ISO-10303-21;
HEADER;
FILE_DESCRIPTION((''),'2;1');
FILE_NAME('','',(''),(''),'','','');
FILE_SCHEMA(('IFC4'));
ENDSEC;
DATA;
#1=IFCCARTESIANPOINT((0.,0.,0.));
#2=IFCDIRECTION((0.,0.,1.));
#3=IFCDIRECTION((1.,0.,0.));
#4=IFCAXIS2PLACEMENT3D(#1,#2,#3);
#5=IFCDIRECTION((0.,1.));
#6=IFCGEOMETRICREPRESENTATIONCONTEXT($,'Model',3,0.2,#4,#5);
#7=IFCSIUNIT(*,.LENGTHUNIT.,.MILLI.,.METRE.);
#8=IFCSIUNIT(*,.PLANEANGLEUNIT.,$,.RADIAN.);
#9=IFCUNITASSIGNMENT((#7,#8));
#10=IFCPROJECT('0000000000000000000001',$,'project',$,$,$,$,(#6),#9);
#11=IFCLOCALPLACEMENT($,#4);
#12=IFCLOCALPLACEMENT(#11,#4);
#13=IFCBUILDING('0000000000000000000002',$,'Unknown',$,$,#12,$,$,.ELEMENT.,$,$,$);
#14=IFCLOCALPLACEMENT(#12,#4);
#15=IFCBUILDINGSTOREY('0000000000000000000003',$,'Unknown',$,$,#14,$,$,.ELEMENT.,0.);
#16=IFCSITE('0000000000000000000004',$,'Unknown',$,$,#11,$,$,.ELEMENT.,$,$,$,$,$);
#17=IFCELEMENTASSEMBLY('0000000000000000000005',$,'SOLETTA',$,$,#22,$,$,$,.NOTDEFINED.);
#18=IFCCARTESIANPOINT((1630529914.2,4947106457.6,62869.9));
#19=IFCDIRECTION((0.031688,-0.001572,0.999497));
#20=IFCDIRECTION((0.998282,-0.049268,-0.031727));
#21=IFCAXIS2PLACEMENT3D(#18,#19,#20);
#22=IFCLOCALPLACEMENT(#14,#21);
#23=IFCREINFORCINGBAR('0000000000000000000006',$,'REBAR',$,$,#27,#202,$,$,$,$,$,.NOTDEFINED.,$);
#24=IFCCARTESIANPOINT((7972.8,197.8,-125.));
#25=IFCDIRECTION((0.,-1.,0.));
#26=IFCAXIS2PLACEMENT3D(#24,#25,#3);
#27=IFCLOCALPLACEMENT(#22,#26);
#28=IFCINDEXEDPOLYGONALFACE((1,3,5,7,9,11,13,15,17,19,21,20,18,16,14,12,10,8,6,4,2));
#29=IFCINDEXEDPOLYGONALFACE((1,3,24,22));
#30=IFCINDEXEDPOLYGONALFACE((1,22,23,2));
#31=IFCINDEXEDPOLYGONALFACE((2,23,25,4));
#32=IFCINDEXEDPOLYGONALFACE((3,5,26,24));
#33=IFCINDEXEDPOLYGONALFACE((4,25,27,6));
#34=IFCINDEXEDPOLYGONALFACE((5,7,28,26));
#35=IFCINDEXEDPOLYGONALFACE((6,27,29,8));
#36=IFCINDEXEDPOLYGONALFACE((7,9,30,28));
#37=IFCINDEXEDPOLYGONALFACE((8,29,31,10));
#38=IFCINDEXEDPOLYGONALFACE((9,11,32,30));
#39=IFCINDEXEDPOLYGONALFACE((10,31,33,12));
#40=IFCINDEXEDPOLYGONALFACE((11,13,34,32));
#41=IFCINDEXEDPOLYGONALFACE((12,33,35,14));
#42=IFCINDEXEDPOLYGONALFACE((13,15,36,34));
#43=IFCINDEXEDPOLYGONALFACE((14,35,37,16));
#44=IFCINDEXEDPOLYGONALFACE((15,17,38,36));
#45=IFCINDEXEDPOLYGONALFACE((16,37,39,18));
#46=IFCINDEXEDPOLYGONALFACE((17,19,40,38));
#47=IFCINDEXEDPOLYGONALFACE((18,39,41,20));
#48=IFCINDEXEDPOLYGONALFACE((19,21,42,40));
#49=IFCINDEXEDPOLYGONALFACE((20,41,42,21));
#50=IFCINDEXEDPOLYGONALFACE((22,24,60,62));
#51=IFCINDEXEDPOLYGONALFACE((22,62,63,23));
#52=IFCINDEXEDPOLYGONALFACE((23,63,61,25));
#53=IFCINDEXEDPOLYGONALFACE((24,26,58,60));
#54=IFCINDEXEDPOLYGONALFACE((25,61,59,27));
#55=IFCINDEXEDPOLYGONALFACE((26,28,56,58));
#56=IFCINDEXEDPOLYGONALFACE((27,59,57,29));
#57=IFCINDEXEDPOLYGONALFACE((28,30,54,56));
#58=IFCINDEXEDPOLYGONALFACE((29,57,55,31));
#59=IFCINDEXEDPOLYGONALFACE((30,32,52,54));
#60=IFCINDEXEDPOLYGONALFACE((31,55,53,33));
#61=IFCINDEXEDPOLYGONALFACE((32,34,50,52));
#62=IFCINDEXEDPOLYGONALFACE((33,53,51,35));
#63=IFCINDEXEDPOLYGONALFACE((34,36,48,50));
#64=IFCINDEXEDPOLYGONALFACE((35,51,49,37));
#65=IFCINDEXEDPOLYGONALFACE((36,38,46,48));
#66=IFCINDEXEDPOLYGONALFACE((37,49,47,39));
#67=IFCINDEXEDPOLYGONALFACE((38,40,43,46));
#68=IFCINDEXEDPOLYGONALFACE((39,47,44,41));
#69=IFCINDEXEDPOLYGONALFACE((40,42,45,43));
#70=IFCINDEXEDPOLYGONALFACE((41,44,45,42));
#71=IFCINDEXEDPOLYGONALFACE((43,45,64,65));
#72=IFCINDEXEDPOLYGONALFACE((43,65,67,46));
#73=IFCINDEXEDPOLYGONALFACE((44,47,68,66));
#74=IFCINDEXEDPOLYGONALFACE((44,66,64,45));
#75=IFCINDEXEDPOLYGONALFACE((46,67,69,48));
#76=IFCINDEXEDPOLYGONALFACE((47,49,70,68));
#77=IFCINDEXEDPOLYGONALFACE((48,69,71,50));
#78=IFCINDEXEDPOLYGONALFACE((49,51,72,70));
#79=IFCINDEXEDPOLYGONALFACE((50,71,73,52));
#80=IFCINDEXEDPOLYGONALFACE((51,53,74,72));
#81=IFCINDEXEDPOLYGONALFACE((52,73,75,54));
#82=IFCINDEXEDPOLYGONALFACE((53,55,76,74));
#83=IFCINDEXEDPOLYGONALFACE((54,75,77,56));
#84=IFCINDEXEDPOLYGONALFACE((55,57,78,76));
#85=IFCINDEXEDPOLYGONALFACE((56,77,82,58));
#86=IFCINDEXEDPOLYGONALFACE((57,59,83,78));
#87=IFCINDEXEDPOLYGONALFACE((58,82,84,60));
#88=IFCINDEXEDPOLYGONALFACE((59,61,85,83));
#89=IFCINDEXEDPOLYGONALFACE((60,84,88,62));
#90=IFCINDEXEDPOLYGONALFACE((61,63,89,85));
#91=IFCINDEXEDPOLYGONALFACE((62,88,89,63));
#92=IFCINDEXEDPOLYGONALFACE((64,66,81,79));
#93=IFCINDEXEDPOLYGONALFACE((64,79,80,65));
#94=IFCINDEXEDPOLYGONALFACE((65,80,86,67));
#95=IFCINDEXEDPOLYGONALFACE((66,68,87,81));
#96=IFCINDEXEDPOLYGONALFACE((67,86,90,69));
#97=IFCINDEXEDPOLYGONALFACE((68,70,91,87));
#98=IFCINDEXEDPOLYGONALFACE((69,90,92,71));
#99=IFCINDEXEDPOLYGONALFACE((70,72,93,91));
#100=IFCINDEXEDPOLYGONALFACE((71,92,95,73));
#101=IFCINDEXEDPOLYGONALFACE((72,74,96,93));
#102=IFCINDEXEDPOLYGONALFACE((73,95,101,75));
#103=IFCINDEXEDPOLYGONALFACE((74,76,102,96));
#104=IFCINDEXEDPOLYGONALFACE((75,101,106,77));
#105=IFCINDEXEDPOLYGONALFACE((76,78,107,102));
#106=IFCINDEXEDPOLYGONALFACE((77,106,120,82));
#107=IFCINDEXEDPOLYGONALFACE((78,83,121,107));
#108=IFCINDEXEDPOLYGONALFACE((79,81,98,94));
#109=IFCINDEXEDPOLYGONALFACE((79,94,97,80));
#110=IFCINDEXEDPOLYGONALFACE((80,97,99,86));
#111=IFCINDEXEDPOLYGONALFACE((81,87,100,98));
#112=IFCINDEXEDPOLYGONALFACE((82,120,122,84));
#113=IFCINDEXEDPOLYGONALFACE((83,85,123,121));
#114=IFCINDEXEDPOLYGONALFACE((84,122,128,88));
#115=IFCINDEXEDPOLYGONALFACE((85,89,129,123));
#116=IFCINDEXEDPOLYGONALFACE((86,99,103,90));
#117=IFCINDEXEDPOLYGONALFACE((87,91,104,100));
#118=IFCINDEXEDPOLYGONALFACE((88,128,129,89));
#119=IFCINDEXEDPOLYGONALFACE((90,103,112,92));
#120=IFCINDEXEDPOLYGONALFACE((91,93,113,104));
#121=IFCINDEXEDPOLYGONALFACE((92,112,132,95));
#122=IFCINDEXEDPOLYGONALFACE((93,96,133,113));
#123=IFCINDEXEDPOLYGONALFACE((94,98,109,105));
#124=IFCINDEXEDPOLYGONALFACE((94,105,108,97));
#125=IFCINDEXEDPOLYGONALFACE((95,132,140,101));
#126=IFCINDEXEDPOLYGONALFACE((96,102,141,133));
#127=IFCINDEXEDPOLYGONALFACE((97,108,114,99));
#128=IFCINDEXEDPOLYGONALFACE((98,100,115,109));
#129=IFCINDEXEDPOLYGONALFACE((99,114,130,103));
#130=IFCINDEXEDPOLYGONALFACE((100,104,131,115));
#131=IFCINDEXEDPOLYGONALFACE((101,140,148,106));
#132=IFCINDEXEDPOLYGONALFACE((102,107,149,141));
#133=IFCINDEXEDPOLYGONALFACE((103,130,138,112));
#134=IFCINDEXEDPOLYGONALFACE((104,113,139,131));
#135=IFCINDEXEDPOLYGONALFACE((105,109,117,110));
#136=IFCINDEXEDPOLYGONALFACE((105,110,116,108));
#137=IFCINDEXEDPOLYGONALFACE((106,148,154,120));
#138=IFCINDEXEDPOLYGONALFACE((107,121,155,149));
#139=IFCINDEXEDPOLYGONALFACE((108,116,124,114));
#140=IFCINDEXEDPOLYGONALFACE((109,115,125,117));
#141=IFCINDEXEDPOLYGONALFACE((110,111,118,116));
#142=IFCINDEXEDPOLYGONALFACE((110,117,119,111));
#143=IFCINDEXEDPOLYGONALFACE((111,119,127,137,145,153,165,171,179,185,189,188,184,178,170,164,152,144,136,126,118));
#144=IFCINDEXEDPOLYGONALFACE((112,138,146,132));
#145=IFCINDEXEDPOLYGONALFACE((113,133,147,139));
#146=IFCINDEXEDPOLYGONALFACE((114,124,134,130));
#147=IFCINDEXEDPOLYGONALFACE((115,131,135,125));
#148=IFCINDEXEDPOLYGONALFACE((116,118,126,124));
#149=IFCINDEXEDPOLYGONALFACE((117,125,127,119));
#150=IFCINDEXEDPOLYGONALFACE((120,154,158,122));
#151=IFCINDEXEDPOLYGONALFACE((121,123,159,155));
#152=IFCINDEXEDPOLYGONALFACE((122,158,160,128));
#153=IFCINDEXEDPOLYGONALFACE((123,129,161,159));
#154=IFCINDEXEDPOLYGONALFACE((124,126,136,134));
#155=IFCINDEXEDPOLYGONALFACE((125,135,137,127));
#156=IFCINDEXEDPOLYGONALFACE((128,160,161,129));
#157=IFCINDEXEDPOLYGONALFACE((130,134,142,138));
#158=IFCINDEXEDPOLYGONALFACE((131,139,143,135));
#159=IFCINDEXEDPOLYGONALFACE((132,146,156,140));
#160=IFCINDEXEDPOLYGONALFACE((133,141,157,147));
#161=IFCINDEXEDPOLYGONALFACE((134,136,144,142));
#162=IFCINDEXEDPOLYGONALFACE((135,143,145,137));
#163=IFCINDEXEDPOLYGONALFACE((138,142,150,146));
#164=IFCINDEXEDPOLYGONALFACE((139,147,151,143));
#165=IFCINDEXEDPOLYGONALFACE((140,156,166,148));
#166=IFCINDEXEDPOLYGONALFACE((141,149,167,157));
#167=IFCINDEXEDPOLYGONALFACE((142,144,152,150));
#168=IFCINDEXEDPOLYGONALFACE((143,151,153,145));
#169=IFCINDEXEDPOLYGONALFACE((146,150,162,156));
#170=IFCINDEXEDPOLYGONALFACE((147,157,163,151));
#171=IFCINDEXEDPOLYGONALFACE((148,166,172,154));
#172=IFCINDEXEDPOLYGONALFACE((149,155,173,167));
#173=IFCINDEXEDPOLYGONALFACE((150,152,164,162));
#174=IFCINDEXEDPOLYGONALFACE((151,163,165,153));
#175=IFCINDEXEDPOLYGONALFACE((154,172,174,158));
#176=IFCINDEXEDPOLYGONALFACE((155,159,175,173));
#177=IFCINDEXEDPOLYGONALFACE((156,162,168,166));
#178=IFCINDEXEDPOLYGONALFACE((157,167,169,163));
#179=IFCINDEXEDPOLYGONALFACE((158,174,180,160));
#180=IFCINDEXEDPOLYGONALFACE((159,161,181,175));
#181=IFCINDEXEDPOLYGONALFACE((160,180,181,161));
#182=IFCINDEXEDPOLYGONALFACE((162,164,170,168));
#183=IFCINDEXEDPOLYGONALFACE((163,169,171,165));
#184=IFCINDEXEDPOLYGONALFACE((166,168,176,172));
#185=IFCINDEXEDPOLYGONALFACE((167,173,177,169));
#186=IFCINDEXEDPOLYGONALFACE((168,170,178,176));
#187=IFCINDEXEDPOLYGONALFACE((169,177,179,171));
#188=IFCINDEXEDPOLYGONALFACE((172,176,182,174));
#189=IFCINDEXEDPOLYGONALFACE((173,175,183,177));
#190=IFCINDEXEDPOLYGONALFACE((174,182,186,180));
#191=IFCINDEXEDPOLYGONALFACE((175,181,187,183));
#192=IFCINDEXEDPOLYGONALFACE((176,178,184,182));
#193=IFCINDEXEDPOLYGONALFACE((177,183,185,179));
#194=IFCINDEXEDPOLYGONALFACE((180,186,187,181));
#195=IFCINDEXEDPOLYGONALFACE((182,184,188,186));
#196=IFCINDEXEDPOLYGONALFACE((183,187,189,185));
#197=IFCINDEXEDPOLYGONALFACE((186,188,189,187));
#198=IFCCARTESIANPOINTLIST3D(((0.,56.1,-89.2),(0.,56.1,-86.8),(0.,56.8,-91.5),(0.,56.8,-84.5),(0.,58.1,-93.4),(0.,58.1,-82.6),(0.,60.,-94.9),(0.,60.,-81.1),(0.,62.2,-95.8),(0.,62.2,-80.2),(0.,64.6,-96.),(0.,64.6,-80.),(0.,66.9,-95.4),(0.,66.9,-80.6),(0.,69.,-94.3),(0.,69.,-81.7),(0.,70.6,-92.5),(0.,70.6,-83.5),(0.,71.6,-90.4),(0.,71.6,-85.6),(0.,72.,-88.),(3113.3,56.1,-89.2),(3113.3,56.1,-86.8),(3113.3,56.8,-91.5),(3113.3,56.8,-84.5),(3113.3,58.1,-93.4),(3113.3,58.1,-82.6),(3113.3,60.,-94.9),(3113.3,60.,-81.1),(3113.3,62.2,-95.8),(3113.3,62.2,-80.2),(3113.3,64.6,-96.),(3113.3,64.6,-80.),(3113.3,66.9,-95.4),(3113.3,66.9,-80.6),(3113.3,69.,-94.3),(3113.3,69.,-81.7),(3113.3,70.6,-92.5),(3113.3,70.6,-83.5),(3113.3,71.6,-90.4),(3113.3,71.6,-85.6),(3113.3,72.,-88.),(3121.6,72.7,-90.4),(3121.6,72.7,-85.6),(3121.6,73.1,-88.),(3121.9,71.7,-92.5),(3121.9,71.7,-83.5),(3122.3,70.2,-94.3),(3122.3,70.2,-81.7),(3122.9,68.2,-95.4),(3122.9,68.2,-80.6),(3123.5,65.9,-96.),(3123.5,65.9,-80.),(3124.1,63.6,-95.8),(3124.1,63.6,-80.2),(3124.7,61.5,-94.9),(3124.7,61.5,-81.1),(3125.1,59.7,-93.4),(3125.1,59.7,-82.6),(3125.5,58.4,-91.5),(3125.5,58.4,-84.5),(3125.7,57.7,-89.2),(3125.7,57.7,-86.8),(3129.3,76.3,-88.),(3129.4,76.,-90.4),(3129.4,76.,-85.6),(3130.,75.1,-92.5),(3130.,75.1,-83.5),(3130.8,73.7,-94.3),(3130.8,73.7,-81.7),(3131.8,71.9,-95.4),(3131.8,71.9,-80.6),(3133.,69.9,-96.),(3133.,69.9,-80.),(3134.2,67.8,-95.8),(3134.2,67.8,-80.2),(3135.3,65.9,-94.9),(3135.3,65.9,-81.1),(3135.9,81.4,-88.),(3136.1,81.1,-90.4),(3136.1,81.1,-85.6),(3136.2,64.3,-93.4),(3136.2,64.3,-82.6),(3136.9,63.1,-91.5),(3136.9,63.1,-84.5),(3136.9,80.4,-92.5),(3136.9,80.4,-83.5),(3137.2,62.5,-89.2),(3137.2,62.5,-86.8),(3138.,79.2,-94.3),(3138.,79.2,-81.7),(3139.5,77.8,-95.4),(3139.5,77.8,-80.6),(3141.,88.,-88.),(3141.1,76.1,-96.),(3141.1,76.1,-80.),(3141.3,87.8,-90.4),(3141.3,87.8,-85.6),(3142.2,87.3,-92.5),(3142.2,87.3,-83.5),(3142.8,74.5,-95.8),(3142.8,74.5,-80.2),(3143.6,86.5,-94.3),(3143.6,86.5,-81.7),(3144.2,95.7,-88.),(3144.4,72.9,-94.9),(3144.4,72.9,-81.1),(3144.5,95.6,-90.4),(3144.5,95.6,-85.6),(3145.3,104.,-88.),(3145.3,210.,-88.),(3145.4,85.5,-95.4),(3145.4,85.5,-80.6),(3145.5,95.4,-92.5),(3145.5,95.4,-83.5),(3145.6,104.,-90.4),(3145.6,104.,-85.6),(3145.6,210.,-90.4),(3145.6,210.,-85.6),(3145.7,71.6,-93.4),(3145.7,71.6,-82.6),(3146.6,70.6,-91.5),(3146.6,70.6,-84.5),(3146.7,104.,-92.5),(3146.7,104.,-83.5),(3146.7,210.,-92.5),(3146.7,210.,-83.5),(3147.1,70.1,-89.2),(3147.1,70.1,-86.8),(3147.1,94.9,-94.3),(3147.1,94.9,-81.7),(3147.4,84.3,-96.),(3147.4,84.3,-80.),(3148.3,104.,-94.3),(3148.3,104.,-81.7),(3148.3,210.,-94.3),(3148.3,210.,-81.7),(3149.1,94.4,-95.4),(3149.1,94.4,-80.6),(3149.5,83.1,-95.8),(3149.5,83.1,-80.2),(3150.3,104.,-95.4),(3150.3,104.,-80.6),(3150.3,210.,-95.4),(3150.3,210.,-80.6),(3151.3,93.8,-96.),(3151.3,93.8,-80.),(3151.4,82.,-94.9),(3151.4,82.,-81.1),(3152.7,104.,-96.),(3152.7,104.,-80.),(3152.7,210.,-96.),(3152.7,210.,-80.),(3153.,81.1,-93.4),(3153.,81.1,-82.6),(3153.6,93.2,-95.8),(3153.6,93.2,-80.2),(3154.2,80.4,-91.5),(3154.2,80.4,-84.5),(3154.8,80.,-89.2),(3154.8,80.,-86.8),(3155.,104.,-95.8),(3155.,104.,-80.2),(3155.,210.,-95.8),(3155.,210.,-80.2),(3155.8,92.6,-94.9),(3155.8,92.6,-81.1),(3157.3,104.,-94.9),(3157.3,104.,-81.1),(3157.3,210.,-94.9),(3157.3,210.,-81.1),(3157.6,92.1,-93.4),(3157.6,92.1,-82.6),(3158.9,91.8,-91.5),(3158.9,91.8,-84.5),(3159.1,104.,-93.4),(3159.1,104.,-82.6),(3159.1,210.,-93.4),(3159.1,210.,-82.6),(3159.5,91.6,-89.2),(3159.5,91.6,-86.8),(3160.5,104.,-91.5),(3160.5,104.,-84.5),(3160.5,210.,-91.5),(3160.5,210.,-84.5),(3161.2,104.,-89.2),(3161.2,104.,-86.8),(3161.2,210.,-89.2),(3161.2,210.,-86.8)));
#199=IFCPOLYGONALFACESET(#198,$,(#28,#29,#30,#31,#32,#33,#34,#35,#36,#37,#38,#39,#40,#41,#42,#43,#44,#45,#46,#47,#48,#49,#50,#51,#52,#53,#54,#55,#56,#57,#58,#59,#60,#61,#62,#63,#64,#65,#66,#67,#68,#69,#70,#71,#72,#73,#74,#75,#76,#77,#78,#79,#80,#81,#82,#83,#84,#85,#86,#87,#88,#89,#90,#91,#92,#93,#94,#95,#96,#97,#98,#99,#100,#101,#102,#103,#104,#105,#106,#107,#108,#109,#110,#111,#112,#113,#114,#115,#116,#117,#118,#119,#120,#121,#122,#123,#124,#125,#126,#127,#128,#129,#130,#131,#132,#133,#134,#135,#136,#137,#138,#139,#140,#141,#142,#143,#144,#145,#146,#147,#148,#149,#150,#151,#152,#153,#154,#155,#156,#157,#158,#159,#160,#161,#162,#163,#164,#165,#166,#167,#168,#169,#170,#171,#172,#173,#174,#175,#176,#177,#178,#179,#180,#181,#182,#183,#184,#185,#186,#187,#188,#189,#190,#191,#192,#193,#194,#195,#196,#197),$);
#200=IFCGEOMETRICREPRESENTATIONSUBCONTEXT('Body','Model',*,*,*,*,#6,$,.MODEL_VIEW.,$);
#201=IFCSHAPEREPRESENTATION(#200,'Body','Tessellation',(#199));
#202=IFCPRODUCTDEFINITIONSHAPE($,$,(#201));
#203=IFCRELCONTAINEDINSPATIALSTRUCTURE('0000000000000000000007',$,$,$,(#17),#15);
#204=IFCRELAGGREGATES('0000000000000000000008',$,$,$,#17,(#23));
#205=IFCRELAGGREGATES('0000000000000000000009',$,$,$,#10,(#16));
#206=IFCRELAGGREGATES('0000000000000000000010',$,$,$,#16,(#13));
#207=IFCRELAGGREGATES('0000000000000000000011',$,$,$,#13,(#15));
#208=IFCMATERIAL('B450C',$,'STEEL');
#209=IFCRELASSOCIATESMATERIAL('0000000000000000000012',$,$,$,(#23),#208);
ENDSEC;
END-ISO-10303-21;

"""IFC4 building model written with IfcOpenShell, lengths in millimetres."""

from ifc_helpers import new_model, entity, si_unit, direction, frame, origin_with_axes, place, context, subcontext, project, spatial, material, element, aggregate, save


model = new_model("IFC4")

# Units and contexts
model_context = context("Model", 3, precision=0.2, world=origin_with_axes(), true_north=direction((0.0, 1.0)))
body_context = subcontext(model_context, "Body", "Model", "MODEL_VIEW")
ifc_project = project(units=[si_unit("LENGTHUNIT", "METRE", prefix="MILLI"), si_unit("PLANEANGLEUNIT", "RADIAN")], contexts=[model_context])

# Site, building, storey
site_placement = place(None, origin_with_axes())
site = spatial("IfcSite", under=ifc_project, at=site_placement, Name="Unknown", CompositionType="ELEMENT")
building_placement = place(site_placement, origin_with_axes())
building = spatial("IfcBuilding", under=site, at=building_placement, Name="Unknown", CompositionType="ELEMENT")
storey_placement = place(building_placement, origin_with_axes())
storey = spatial("IfcBuildingStorey", under=building, at=storey_placement, Name="Unknown", CompositionType="ELEMENT", Elevation=0.0)

# Element assembly
ifc_material = material(Name="B450C", Category="STEEL")
assembly_1_placement = place(storey_placement, frame((1630529914.2, 4947106457.6, 62869.9), z_axis=(0.031688, -0.001572, 0.999497), x_axis=(0.998282, -0.049268, -0.031727)))
assembly_1 = element("IfcElementAssembly", 1, at=assembly_1_placement, inside=storey, Name="SOLETTA", PredefinedType="NOTDEFINED")

# Reinforcing bar
reinforcing_bar_1_placement = place(assembly_1_placement, frame((7972.8, 197.8, -125.0), z_axis=(0.0, -1.0, 0.0), x_axis=(1.0, 0.0, 0.0)))
reinforcing_bar_1 = element("IfcReinforcingBar", 2, at=reinforcing_bar_1_placement, material=ifc_material, Name="REBAR", PredefinedType="NOTDEFINED", context=body_context, shape_type="AdvancedSweptSolid", body=[
    entity("IfcSweptDiskSolid", entity("IfcIndexedPolyCurve", entity("IfcCartesianPointList3D", [[0.0, 64.0, -88.0], [3113.3, 64.0, -88.0], [3141.6, 75.7, -88.0], [3153.3, 104.0, -88.0], [3153.3, 210.0, -88.0]]), [entity("IfcLineIndex", [1, 2]), entity("IfcArcIndex", [2, 3, 4]), entity("IfcLineIndex", [4, 5])]), 8.0),
])
aggregate(assembly_1, [reinforcing_bar_1])

save(model, "model.ifc")
